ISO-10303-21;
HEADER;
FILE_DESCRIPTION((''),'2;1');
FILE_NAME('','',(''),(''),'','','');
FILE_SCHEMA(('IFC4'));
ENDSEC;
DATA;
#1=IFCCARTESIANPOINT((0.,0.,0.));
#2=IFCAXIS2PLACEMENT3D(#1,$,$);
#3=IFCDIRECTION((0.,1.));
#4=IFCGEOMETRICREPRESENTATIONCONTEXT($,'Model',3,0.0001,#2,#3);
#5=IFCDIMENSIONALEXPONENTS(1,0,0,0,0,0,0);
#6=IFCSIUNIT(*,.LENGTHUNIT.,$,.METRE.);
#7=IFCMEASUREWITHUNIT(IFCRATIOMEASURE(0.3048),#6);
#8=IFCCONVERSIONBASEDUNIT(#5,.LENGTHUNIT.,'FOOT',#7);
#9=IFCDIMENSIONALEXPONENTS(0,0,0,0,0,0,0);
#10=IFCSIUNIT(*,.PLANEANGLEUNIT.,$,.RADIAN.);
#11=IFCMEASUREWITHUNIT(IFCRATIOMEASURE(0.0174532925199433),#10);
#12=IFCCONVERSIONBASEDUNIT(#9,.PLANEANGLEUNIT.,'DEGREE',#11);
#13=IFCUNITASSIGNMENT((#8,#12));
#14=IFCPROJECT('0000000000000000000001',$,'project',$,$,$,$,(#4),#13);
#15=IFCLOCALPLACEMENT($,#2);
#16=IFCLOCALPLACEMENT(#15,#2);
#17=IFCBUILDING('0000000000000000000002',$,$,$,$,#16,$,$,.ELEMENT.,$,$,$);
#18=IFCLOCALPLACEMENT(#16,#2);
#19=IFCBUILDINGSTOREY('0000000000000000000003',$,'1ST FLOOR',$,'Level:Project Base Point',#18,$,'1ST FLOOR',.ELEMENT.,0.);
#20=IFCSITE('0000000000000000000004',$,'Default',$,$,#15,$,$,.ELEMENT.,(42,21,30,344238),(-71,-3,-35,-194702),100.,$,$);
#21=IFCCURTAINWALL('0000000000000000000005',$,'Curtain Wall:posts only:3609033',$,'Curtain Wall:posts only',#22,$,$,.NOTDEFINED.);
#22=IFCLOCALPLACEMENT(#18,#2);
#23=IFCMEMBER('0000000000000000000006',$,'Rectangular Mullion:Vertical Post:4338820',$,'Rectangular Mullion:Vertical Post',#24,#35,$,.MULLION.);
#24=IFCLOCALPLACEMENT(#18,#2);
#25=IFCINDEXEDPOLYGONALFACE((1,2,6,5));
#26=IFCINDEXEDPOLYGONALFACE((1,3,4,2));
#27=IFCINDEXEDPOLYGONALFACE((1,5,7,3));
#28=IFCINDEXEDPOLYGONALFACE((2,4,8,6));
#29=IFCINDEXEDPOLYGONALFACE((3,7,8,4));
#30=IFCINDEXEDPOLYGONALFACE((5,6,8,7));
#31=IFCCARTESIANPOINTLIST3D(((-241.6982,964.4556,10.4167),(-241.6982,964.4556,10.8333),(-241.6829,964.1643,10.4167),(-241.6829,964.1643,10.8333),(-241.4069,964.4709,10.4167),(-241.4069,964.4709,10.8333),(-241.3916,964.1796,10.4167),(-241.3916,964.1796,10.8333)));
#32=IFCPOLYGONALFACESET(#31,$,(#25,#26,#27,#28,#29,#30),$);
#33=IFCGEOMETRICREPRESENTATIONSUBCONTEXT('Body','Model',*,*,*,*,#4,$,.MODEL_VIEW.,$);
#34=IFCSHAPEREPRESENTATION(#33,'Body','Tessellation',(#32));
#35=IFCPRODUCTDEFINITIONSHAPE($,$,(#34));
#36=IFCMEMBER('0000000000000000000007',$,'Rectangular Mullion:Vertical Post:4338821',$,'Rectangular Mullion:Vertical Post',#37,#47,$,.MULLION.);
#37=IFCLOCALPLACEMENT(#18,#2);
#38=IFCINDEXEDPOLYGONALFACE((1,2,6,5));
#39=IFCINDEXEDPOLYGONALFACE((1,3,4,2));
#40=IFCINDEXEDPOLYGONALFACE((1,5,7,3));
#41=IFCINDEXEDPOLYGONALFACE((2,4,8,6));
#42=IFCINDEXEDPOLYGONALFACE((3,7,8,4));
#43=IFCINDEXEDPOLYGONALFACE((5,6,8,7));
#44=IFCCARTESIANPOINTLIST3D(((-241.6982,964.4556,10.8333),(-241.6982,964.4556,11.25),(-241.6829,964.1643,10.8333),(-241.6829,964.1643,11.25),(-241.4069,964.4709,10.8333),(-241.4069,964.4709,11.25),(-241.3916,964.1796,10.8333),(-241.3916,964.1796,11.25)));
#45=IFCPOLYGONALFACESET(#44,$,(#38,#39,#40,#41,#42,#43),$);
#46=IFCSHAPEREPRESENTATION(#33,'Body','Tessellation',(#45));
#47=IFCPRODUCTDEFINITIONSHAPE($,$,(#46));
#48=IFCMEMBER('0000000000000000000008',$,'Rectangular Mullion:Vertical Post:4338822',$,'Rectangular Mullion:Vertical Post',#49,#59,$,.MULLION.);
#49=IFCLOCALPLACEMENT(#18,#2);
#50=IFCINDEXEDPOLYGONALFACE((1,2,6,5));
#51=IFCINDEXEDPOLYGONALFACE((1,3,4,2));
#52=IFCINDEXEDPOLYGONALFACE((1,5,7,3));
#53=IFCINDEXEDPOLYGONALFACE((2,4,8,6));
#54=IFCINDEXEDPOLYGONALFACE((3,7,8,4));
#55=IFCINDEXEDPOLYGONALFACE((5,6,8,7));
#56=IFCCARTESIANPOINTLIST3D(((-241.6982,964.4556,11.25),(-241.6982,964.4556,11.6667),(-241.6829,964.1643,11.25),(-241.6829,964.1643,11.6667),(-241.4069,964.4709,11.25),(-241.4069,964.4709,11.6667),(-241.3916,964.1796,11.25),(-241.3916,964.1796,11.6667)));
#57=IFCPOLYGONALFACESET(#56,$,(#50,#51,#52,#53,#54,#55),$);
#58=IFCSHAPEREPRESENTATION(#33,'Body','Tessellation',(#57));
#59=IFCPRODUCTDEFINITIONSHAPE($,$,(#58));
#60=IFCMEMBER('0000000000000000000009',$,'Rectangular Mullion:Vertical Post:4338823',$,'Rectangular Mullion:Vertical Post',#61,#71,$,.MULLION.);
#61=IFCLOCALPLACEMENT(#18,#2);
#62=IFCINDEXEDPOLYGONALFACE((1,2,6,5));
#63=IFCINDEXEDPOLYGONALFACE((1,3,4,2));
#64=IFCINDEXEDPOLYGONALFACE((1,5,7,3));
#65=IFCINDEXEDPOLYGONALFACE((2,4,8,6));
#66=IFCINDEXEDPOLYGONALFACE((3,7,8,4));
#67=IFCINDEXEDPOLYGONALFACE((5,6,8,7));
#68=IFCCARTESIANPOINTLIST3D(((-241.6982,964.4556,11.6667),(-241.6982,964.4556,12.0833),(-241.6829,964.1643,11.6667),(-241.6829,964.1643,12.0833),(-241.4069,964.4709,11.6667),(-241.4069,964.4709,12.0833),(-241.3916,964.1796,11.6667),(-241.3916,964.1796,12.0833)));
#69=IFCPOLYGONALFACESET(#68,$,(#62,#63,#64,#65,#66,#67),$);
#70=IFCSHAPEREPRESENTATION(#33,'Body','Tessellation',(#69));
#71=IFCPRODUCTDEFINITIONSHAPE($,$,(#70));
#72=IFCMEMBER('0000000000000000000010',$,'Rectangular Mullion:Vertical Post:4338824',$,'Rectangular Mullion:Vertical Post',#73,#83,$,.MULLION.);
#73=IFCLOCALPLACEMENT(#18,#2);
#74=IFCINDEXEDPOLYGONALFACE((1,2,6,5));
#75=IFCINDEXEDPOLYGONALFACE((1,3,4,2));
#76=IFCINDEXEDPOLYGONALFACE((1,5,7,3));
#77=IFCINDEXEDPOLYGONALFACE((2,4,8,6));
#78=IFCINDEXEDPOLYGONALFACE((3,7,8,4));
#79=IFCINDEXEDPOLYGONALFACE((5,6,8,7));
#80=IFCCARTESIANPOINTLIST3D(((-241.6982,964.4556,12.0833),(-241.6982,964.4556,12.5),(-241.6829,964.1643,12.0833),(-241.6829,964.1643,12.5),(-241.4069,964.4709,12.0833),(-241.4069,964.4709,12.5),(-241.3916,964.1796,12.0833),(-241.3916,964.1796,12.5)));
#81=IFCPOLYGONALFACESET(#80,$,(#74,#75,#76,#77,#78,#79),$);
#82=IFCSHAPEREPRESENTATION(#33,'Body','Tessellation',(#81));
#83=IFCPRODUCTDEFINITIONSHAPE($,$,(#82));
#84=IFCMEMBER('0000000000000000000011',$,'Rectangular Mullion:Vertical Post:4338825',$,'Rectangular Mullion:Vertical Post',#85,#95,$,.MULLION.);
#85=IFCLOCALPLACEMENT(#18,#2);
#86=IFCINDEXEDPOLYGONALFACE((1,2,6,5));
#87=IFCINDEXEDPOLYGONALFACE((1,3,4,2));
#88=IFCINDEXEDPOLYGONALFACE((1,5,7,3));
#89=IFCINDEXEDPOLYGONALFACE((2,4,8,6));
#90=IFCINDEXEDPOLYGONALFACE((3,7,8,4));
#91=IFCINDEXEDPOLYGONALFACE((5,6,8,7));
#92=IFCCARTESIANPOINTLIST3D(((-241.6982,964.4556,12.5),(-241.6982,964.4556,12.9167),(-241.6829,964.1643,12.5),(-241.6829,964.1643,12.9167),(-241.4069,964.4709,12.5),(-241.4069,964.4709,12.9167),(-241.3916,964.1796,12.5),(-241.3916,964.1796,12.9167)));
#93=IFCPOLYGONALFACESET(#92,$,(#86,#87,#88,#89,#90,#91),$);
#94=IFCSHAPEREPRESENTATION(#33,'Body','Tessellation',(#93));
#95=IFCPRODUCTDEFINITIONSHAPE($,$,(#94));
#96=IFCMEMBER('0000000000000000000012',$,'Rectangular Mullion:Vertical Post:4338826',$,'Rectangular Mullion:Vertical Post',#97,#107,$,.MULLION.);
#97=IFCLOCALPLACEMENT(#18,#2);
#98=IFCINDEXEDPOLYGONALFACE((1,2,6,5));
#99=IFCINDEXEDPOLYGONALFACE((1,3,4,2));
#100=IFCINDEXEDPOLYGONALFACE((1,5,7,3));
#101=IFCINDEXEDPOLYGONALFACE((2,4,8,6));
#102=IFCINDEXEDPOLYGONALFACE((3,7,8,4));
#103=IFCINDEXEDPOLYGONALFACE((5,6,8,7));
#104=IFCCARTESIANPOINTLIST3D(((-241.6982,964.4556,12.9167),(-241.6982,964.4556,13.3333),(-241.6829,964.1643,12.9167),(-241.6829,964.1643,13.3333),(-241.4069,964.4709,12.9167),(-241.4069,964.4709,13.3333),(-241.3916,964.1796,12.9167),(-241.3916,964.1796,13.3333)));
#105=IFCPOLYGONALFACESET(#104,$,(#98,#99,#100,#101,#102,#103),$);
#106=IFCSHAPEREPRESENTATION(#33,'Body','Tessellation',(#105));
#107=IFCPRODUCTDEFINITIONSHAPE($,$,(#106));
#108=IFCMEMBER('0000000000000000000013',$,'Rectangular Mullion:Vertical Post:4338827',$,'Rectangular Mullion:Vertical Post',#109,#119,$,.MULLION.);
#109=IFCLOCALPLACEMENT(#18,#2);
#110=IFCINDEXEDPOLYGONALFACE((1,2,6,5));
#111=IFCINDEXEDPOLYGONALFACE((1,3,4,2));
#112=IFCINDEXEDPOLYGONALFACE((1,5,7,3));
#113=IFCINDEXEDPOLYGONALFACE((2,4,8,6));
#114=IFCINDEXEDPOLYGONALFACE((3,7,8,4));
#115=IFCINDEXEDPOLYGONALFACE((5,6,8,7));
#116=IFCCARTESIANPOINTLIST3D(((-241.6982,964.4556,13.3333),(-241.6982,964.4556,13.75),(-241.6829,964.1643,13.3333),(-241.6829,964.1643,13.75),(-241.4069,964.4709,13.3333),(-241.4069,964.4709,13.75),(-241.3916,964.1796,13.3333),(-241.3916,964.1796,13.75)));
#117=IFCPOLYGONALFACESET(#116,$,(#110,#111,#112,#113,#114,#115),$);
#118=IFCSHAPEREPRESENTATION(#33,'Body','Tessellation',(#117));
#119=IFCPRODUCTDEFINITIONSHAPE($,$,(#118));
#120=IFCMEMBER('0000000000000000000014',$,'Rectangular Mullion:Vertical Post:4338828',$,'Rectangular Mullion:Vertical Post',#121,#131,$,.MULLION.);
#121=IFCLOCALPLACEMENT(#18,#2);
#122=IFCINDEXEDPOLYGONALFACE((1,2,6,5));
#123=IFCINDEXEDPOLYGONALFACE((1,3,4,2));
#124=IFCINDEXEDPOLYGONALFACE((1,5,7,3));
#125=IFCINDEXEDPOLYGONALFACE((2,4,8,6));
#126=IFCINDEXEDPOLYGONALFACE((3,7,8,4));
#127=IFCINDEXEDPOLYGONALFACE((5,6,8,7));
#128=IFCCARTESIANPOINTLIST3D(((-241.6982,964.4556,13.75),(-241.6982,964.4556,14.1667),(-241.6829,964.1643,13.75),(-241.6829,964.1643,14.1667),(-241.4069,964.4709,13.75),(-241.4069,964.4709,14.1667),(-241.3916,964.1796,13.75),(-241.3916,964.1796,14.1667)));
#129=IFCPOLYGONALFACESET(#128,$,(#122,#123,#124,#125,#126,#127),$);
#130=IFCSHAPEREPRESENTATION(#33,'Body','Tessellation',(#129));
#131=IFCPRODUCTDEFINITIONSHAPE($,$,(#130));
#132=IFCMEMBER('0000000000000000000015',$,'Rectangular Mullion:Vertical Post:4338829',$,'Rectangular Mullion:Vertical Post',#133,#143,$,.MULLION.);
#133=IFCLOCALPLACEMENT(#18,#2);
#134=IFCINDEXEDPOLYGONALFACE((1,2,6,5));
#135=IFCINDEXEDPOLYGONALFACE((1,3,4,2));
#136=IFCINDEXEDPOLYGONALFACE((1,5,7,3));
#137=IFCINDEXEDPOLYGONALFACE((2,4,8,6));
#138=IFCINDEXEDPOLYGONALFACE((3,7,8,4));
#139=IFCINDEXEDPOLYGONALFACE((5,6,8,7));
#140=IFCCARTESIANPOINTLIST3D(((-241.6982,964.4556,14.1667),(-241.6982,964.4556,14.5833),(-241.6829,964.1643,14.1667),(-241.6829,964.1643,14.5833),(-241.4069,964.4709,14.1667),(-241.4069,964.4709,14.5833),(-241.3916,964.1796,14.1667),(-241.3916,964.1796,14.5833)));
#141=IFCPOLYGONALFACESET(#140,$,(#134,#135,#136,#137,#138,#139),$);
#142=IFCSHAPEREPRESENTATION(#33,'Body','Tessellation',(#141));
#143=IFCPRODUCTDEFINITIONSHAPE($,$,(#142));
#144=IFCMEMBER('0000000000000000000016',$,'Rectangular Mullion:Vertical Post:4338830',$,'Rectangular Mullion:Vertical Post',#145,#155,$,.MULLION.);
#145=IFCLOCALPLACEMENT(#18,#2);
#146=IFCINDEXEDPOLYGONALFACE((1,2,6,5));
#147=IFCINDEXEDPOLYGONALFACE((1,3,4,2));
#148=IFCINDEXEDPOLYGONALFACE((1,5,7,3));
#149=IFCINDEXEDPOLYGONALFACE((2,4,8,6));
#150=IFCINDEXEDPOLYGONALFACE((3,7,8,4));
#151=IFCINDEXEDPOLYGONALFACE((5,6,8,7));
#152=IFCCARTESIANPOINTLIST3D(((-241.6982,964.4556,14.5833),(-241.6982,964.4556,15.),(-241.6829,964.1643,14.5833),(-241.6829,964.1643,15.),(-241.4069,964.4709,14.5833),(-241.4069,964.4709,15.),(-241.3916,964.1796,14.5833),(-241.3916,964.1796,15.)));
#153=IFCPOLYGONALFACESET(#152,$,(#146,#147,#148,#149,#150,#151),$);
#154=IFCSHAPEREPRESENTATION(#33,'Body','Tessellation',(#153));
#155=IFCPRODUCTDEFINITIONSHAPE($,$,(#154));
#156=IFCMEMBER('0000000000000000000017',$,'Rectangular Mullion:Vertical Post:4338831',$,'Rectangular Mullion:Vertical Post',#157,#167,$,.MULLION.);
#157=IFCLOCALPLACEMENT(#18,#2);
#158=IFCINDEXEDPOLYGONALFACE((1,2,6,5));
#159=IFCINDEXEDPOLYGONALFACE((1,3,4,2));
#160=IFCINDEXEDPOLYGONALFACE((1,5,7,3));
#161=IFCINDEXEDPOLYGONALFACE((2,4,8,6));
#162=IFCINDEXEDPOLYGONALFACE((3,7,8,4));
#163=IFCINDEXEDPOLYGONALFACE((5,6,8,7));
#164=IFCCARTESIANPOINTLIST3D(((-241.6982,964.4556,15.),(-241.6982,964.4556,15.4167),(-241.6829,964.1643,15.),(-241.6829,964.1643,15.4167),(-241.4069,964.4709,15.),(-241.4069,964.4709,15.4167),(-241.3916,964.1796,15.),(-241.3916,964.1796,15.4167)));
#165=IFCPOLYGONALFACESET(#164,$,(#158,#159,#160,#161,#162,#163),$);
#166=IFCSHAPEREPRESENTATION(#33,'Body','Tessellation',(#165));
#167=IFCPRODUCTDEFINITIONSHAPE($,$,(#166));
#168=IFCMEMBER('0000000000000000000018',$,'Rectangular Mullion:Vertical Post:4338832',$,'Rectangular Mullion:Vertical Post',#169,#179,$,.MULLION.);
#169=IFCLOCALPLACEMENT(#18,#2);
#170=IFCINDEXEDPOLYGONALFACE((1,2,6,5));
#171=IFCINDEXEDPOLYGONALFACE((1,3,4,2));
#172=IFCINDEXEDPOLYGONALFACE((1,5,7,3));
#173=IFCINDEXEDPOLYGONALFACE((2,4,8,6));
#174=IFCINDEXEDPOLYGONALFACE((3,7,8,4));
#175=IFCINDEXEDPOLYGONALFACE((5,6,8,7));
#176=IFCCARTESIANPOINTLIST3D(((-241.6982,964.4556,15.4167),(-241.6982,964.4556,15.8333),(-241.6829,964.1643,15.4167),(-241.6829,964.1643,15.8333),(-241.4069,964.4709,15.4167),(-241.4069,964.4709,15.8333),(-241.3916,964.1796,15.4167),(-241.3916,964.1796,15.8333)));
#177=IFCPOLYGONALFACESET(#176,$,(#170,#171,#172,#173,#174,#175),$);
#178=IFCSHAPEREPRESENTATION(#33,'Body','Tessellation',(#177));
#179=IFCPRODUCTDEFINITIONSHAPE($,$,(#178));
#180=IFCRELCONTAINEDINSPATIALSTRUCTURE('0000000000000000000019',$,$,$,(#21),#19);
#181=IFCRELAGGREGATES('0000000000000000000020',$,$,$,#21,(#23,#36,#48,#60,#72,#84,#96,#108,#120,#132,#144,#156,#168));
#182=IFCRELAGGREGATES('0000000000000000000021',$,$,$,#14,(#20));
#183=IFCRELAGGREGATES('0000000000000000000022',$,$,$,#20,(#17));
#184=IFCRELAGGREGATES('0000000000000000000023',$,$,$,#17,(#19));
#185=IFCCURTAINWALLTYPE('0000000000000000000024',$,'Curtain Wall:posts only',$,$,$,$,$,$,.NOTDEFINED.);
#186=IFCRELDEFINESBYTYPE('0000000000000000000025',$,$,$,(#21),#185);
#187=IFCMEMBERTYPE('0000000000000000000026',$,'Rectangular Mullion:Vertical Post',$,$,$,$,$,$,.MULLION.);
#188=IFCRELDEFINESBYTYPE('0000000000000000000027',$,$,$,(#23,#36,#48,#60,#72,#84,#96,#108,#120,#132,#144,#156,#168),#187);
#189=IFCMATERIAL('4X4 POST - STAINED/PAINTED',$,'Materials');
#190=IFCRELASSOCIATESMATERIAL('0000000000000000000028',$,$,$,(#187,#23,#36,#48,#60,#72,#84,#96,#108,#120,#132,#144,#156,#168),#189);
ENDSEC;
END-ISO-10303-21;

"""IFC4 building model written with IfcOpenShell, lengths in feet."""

from ifc_helpers import new_model, entity, si_unit, converted_unit, direction, frame, origin, origin_2d_with_axis, place, context, subcontext, project, spatial, rectangle, extrude, source, transform, mapped, material, material_profile, profile_set, profile_usage, type_object, type_shapes, element, aggregate, save


model = new_model("IFC4")

# Units and contexts
model_context = context("Model", 3, precision=0.0001, world=origin(), true_north=direction((0.0, 1.0)))
body_context = subcontext(model_context, "Body", "Model", "MODEL_VIEW")
ifc_project = project(units=[converted_unit("LENGTHUNIT", "FOOT", entity("IfcRatioMeasure", 0.3048), si_unit("LENGTHUNIT", "METRE"), dimensions=[1, 0, 0, 0, 0, 0, 0]), converted_unit("PLANEANGLEUNIT", "DEGREE", entity("IfcRatioMeasure", 0.0174532925199433), si_unit("PLANEANGLEUNIT", "RADIAN"), dimensions=[0, 0, 0, 0, 0, 0, 0])], contexts=[model_context])

# Site, building, storey
site_placement = place(None, origin())
site = spatial("IfcSite", under=ifc_project, at=site_placement, Name="Default", CompositionType="ELEMENT", RefLatitude=(42, 21, 30, 344238), RefLongitude=(-71, -3, -35, -194702), RefElevation=100.0)
building_placement = place(site_placement, origin())
building = spatial("IfcBuilding", under=site, at=building_placement, CompositionType="ELEMENT")
storey_placement = place(building_placement, origin())
storey = spatial("IfcBuildingStorey", under=building, at=storey_placement, Name="1ST FLOOR", ObjectType="Level:Project Base Point", LongName="1ST FLOOR", CompositionType="ELEMENT", Elevation=0.0)

# Curtain wall, members
curtain_wall_type_1 = type_object("IfcCurtainWallType", Name="Curtain Wall:posts only", PredefinedType="NOTDEFINED")
curtain_wall_1_placement = place(storey_placement, origin())
curtain_wall_1 = element("IfcCurtainWall", 1, at=curtain_wall_1_placement, inside=storey, type_object=curtain_wall_type_1, Name="Curtain Wall:posts only:3609033", ObjectType="Curtain Wall:posts only", PredefinedType="NOTDEFINED")
ifc_material_1 = material(Name="4X4 POST - STAINED/PAINTED", Category="Materials")
ifc_material_profile_1 = material_profile(ifc_material_1, rectangle(XDim=0.2917, YDim=0.2917, at=origin_2d_with_axis()), Name="Vertical Post")
ifc_profile_set_1 = profile_set([ifc_material_profile_1], Name="Vertical Post")
ifc_profile_usage_1 = profile_usage(ifc_profile_set_1)
member_type_1 = type_object("IfcMemberType", Name="Rectangular Mullion:Vertical Post", PredefinedType="MULLION", material=ifc_profile_set_1)
shared_shape_1 = source(origin(), body_context, "Body", "SweptSolid", [
    extrude(rectangle(XDim=0.2917, YDim=0.2917, at=origin_2d_with_axis()), frame((0.0, -0.2083, -0.4167), z_axis=(0.0, 0.0, 1.0), x_axis=(0.0, -1.0, 0.0)), (0.0, 0.0, 1.0), 0.4167),
])
type_shapes(member_type_1, [shared_shape_1])
member_1_placement = place(storey_placement, frame((-241.5558, 964.5256, 10.4167), z_axis=(0.0, 0.0, -1.0), x_axis=(-0.99863, -0.052336, 0.0)))
member_1 = element("IfcMember", 2, at=member_1_placement, type_object=member_type_1, material=ifc_profile_usage_1, Name="Rectangular Mullion:Vertical Post:4338820", ObjectType="Rectangular Mullion:Vertical Post", PredefinedType="MULLION", context=body_context, shape_type="MappedRepresentation", body=[
    mapped(shared_shape_1, transform((0.0, 0.0, 0.0), scale=1.0)),
])
ifc_profile_usage_2 = profile_usage(ifc_profile_set_1)
member_2_placement = place(storey_placement, frame((-241.5558, 964.5256, 10.8333), z_axis=(0.0, 0.0, -1.0), x_axis=(-0.99863, -0.052336, 0.0)))
member_2 = element("IfcMember", 3, at=member_2_placement, type_object=member_type_1, material=ifc_profile_usage_2, Name="Rectangular Mullion:Vertical Post:4338821", ObjectType="Rectangular Mullion:Vertical Post", PredefinedType="MULLION", context=body_context, shape_type="MappedRepresentation", body=[
    mapped(shared_shape_1, transform((0.0, 0.0, 0.0), scale=1.0)),
])
ifc_profile_usage_3 = profile_usage(ifc_profile_set_1)
member_3_placement = place(storey_placement, frame((-241.5558, 964.5256, 11.25), z_axis=(0.0, 0.0, -1.0), x_axis=(-0.99863, -0.052336, 0.0)))
member_3 = element("IfcMember", 4, at=member_3_placement, type_object=member_type_1, material=ifc_profile_usage_3, Name="Rectangular Mullion:Vertical Post:4338822", ObjectType="Rectangular Mullion:Vertical Post", PredefinedType="MULLION", context=body_context, shape_type="MappedRepresentation", body=[
    mapped(shared_shape_1, transform((0.0, 0.0, 0.0), scale=1.0)),
])
ifc_profile_usage_4 = profile_usage(ifc_profile_set_1)
member_4_placement = place(storey_placement, frame((-241.5558, 964.5256, 11.6667), z_axis=(0.0, 0.0, -1.0), x_axis=(-0.99863, -0.052336, 0.0)))
member_4 = element("IfcMember", 5, at=member_4_placement, type_object=member_type_1, material=ifc_profile_usage_4, Name="Rectangular Mullion:Vertical Post:4338823", ObjectType="Rectangular Mullion:Vertical Post", PredefinedType="MULLION", context=body_context, shape_type="MappedRepresentation", body=[
    mapped(shared_shape_1, transform((0.0, 0.0, 0.0), scale=1.0)),
])
ifc_profile_usage_5 = profile_usage(ifc_profile_set_1)
member_5_placement = place(storey_placement, frame((-241.5558, 964.5256, 12.0833), z_axis=(0.0, 0.0, -1.0), x_axis=(-0.99863, -0.052336, 0.0)))
member_5 = element("IfcMember", 6, at=member_5_placement, type_object=member_type_1, material=ifc_profile_usage_5, Name="Rectangular Mullion:Vertical Post:4338824", ObjectType="Rectangular Mullion:Vertical Post", PredefinedType="MULLION", context=body_context, shape_type="MappedRepresentation", body=[
    mapped(shared_shape_1, transform((0.0, 0.0, 0.0), scale=1.0)),
])
ifc_profile_usage_6 = profile_usage(ifc_profile_set_1)
member_6_placement = place(storey_placement, frame((-241.5558, 964.5256, 12.5), z_axis=(0.0, 0.0, -1.0), x_axis=(-0.99863, -0.052336, 0.0)))
member_6 = element("IfcMember", 7, at=member_6_placement, type_object=member_type_1, material=ifc_profile_usage_6, Name="Rectangular Mullion:Vertical Post:4338825", ObjectType="Rectangular Mullion:Vertical Post", PredefinedType="MULLION", context=body_context, shape_type="MappedRepresentation", body=[
    mapped(shared_shape_1, transform((0.0, 0.0, 0.0), scale=1.0)),
])
ifc_profile_usage_7 = profile_usage(ifc_profile_set_1)
member_7_placement = place(storey_placement, frame((-241.5558, 964.5256, 12.9167), z_axis=(0.0, 0.0, -1.0), x_axis=(-0.99863, -0.052336, 0.0)))
member_7 = element("IfcMember", 8, at=member_7_placement, type_object=member_type_1, material=ifc_profile_usage_7, Name="Rectangular Mullion:Vertical Post:4338826", ObjectType="Rectangular Mullion:Vertical Post", PredefinedType="MULLION", context=body_context, shape_type="MappedRepresentation", body=[
    mapped(shared_shape_1, transform((0.0, 0.0, 0.0), scale=1.0)),
])
ifc_profile_usage_8 = profile_usage(ifc_profile_set_1)
member_8_placement = place(storey_placement, frame((-241.5558, 964.5256, 13.3333), z_axis=(0.0, 0.0, -1.0), x_axis=(-0.99863, -0.052336, 0.0)))
member_8 = element("IfcMember", 9, at=member_8_placement, type_object=member_type_1, material=ifc_profile_usage_8, Name="Rectangular Mullion:Vertical Post:4338827", ObjectType="Rectangular Mullion:Vertical Post", PredefinedType="MULLION", context=body_context, shape_type="MappedRepresentation", body=[
    mapped(shared_shape_1, transform((0.0, 0.0, 0.0), scale=1.0)),
])
ifc_profile_usage_9 = profile_usage(ifc_profile_set_1)
member_9_placement = place(storey_placement, frame((-241.5558, 964.5256, 13.75), z_axis=(0.0, 0.0, -1.0), x_axis=(-0.99863, -0.052336, 0.0)))
member_9 = element("IfcMember", 10, at=member_9_placement, type_object=member_type_1, material=ifc_profile_usage_9, Name="Rectangular Mullion:Vertical Post:4338828", ObjectType="Rectangular Mullion:Vertical Post", PredefinedType="MULLION", context=body_context, shape_type="MappedRepresentation", body=[
    mapped(shared_shape_1, transform((0.0, 0.0, 0.0), scale=1.0)),
])
ifc_profile_usage_10 = profile_usage(ifc_profile_set_1)
member_10_placement = place(storey_placement, frame((-241.5558, 964.5256, 14.1667), z_axis=(0.0, 0.0, -1.0), x_axis=(-0.99863, -0.052336, 0.0)))
member_10 = element("IfcMember", 11, at=member_10_placement, type_object=member_type_1, material=ifc_profile_usage_10, Name="Rectangular Mullion:Vertical Post:4338829", ObjectType="Rectangular Mullion:Vertical Post", PredefinedType="MULLION", context=body_context, shape_type="MappedRepresentation", body=[
    mapped(shared_shape_1, transform((0.0, 0.0, 0.0), scale=1.0)),
])
ifc_profile_usage_11 = profile_usage(ifc_profile_set_1)
member_11_placement = place(storey_placement, frame((-241.5558, 964.5256, 14.5833), z_axis=(0.0, 0.0, -1.0), x_axis=(-0.99863, -0.052336, 0.0)))
member_11 = element("IfcMember", 12, at=member_11_placement, type_object=member_type_1, material=ifc_profile_usage_11, Name="Rectangular Mullion:Vertical Post:4338830", ObjectType="Rectangular Mullion:Vertical Post", PredefinedType="MULLION", context=body_context, shape_type="MappedRepresentation", body=[
    mapped(shared_shape_1, transform((0.0, 0.0, 0.0), scale=1.0)),
])
ifc_profile_usage_12 = profile_usage(ifc_profile_set_1)
member_12_placement = place(storey_placement, frame((-241.5558, 964.5256, 15.0), z_axis=(0.0, 0.0, -1.0), x_axis=(-0.99863, -0.052336, 0.0)))
member_12 = element("IfcMember", 13, at=member_12_placement, type_object=member_type_1, material=ifc_profile_usage_12, Name="Rectangular Mullion:Vertical Post:4338831", ObjectType="Rectangular Mullion:Vertical Post", PredefinedType="MULLION", context=body_context, shape_type="MappedRepresentation", body=[
    mapped(shared_shape_1, transform((0.0, 0.0, 0.0), scale=1.0)),
])
ifc_profile_usage_13 = profile_usage(ifc_profile_set_1)
member_13_placement = place(storey_placement, frame((-241.5558, 964.5256, 15.4167), z_axis=(0.0, 0.0, -1.0), x_axis=(-0.99863, -0.052336, 0.0)))
member_13 = element("IfcMember", 14, at=member_13_placement, type_object=member_type_1, material=ifc_profile_usage_13, Name="Rectangular Mullion:Vertical Post:4338832", ObjectType="Rectangular Mullion:Vertical Post", PredefinedType="MULLION", context=body_context, shape_type="MappedRepresentation", body=[
    mapped(shared_shape_1, transform((0.0, 0.0, 0.0), scale=1.0)),
])
aggregate(curtain_wall_1, [member_1, member_2, member_3, member_4, member_5, member_6, member_7, member_8, member_9, member_10, member_11, member_12, member_13])

save(model, "model.ifc")
